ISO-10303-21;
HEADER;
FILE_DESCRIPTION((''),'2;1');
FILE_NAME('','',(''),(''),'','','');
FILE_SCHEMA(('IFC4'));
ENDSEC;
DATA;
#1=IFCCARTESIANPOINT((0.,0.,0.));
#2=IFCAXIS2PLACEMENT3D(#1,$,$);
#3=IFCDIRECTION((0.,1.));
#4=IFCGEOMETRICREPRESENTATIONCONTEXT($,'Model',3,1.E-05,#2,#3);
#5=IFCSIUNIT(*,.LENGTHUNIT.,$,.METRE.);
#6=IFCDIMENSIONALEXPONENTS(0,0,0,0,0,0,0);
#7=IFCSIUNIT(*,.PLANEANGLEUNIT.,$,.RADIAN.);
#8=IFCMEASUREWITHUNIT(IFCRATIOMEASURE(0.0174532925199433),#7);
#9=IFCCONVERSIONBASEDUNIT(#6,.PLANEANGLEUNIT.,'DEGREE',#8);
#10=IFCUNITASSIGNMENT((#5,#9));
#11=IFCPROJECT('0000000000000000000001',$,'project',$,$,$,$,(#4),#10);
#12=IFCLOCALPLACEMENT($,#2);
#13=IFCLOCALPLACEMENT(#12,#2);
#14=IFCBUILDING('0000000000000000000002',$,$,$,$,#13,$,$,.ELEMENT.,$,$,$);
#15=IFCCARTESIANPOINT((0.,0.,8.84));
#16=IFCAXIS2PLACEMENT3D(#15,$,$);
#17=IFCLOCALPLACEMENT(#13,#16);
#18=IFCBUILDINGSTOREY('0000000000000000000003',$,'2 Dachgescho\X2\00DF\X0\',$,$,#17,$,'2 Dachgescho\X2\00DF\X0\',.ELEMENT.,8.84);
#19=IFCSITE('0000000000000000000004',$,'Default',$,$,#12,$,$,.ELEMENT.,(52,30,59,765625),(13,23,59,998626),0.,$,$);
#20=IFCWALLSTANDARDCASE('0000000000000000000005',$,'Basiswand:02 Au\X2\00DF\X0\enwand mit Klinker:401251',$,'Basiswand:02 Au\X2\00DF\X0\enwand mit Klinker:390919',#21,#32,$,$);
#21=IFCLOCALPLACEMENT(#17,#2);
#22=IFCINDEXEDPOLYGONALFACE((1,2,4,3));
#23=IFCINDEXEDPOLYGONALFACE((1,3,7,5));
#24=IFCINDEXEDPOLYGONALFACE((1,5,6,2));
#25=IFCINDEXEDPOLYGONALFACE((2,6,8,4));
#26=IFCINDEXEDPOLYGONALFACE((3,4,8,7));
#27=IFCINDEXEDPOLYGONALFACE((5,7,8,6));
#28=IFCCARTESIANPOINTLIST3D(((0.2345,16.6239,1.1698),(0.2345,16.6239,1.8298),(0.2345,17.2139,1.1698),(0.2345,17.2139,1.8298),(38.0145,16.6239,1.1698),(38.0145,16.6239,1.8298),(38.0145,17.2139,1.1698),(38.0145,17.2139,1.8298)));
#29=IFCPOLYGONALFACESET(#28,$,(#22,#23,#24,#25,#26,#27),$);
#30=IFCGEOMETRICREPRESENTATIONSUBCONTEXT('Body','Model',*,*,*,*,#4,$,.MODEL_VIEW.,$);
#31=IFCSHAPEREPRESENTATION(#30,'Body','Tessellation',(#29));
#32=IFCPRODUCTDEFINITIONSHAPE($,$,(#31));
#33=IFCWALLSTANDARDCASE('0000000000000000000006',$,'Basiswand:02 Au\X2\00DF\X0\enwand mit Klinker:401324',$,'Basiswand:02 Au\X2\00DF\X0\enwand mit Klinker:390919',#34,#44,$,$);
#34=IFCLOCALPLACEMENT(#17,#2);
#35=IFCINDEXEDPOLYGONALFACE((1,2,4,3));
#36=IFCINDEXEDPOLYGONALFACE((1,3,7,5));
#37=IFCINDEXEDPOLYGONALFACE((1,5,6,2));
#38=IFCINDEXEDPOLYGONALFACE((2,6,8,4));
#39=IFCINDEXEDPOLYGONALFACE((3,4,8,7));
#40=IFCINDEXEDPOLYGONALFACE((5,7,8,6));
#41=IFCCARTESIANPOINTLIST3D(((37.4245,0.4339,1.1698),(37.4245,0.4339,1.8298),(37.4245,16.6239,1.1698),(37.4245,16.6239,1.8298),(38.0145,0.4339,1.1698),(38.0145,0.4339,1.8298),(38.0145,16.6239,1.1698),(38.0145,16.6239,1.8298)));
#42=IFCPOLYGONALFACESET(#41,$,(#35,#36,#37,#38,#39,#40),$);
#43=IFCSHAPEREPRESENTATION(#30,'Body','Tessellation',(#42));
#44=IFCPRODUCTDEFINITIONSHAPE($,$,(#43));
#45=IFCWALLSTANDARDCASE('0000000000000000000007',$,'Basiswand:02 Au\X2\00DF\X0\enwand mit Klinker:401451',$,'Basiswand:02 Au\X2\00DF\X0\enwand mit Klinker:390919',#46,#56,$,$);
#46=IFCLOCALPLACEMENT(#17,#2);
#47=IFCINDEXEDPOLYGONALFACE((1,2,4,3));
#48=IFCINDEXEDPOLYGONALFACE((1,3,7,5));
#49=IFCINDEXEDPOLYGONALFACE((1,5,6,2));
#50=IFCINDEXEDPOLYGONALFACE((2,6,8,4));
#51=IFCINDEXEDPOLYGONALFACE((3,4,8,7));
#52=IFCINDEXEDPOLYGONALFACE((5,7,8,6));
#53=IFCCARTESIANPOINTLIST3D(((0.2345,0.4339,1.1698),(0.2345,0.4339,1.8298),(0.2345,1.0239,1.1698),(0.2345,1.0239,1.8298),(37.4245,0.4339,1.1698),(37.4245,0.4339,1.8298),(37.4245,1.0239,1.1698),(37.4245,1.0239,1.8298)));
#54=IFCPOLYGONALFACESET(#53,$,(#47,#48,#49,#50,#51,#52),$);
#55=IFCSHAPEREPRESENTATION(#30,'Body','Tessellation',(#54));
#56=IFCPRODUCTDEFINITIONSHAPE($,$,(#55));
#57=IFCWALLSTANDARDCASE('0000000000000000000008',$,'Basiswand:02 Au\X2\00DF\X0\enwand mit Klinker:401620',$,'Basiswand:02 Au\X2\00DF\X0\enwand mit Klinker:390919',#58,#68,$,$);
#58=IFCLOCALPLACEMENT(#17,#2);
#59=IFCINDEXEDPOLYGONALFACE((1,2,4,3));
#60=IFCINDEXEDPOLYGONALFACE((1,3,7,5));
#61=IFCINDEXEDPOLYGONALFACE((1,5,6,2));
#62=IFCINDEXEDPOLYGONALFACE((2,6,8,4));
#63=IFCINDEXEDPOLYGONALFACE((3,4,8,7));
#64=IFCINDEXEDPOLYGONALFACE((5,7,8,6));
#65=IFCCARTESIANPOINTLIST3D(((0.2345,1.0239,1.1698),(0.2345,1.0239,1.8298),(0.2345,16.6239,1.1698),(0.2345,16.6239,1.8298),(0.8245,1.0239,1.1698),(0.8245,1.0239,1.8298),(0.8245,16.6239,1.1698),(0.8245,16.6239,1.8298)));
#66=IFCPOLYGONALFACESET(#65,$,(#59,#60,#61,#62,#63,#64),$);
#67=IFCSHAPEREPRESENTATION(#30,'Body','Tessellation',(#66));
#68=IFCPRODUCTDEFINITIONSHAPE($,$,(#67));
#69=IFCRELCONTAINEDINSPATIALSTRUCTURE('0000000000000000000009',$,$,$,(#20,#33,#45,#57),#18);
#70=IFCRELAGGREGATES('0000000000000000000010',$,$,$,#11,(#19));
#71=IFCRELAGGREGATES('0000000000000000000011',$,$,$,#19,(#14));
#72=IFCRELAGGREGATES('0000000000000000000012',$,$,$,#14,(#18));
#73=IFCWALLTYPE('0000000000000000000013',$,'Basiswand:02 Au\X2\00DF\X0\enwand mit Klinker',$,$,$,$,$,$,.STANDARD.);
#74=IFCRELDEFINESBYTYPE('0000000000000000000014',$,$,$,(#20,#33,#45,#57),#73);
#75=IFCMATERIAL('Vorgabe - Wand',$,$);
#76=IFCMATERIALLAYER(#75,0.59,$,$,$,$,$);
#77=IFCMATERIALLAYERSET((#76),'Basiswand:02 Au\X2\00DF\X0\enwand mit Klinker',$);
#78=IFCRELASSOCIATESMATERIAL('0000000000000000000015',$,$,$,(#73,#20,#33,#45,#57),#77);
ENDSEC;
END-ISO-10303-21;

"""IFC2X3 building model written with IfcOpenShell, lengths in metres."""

from ifc_helpers import new_model, entity, si_unit, converted_unit, direction, frame, frame_2d, origin, place, context, subcontext, project, spatial, rectangle, extrude, material, layer, layer_set, layer_usage, type_object, element, save


model = new_model("IFC2X3")

# Units and contexts
model_context = context("Model", 3, precision=1e-05, world=origin(), true_north=direction((0.0, 1.0)))
body_context = subcontext(model_context, "Body", "Model", "MODEL_VIEW")
ifc_project = project(units=[si_unit("LENGTHUNIT", "METRE"), converted_unit("PLANEANGLEUNIT", "DEGREE", entity("IfcRatioMeasure", 0.0174532925199433), si_unit("PLANEANGLEUNIT", "RADIAN"), dimensions=[0, 0, 0, 0, 0, 0, 0])], contexts=[model_context])

# Site, building, storey
site_placement = place(None, origin())
site = spatial("IfcSite", under=ifc_project, at=site_placement, Name="Default", CompositionType="ELEMENT", RefLatitude=(52, 30, 59, 765625), RefLongitude=(13, 23, 59, 998626), RefElevation=0.0)
building_placement = place(site_placement, origin())
building = spatial("IfcBuilding", under=site, at=building_placement, CompositionType="ELEMENT")
storey_placement = place(building_placement, frame((0.0, 0.0, 8.84)))
storey = spatial("IfcBuildingStorey", under=building, at=storey_placement, Name="2 Dachgeschoß", LongName="2 Dachgeschoß", CompositionType="ELEMENT", Elevation=8.84)

# Walls
ifc_material_1 = material(Name="Vorgabe - Wand")
ifc_layer_1 = layer(ifc_material_1, 0.59)
ifc_layer_set_1 = layer_set([ifc_layer_1], Name="Basiswand:02 Außenwand mit Klinker")
ifc_layer_usage_1 = layer_usage(ifc_layer_set_1, "AXIS2", "NEGATIVE", 0.295)
wall_type = type_object("IfcWallType", Name="Basiswand:02 Außenwand mit Klinker", PredefinedType="STANDARD", material=ifc_layer_set_1)
wall_1_placement = place(storey_placement, frame((0.2345, 16.9189, 1.1698), z_axis=(0.0, 0.0, 1.0), x_axis=(1.0, 0.0, 0.0)))
element("IfcWallStandardCase", 1, at=wall_1_placement, inside=storey, type_object=wall_type, material=ifc_layer_usage_1, Name="Basiswand:02 Außenwand mit Klinker:401251", ObjectType="Basiswand:02 Außenwand mit Klinker:390919", context=body_context, shape_type="SweptSolid", body=[
    extrude(rectangle(XDim=37.78, YDim=0.59, at=frame_2d((18.89, 0.0), x_axis=(-1.0, 0.0))), origin(), (0.0, 0.0, 1.0), 0.66),
])
ifc_layer_usage_2 = layer_usage(ifc_layer_set_1, "AXIS2", "NEGATIVE", 0.295)
wall_2_placement = place(storey_placement, frame((37.7195, 16.6239, 1.1698), z_axis=(0.0, 0.0, 1.0), x_axis=(0.0, -1.0, 0.0)))
element("IfcWallStandardCase", 2, at=wall_2_placement, inside=storey, type_object=wall_type, material=ifc_layer_usage_2, Name="Basiswand:02 Außenwand mit Klinker:401324", ObjectType="Basiswand:02 Außenwand mit Klinker:390919", context=body_context, shape_type="SweptSolid", body=[
    extrude(rectangle(XDim=16.19, YDim=0.59, at=frame_2d((8.095, 0.0), x_axis=(-1.0, 0.0))), origin(), (0.0, 0.0, 1.0), 0.66),
])
ifc_layer_usage_3 = layer_usage(ifc_layer_set_1, "AXIS2", "NEGATIVE", 0.295)
wall_3_placement = place(storey_placement, frame((37.4245, 0.7289, 1.1698), z_axis=(0.0, 0.0, 1.0), x_axis=(-1.0, 0.0, 0.0)))
element("IfcWallStandardCase", 3, at=wall_3_placement, inside=storey, type_object=wall_type, material=ifc_layer_usage_3, Name="Basiswand:02 Außenwand mit Klinker:401451", ObjectType="Basiswand:02 Außenwand mit Klinker:390919", context=body_context, shape_type="SweptSolid", body=[
    extrude(rectangle(XDim=37.19, YDim=0.59, at=frame_2d((18.595, 0.0), x_axis=(-1.0, 0.0))), origin(), (0.0, 0.0, 1.0), 0.66),
])
ifc_layer_usage_4 = layer_usage(ifc_layer_set_1, "AXIS2", "NEGATIVE", 0.295)
wall_4_placement = place(storey_placement, frame((0.5295, 1.0239, 1.1698), z_axis=(0.0, 0.0, 1.0), x_axis=(0.0, 1.0, 0.0)))
element("IfcWallStandardCase", 4, at=wall_4_placement, inside=storey, type_object=wall_type, material=ifc_layer_usage_4, Name="Basiswand:02 Außenwand mit Klinker:401620", ObjectType="Basiswand:02 Außenwand mit Klinker:390919", context=body_context, shape_type="SweptSolid", body=[
    extrude(rectangle(XDim=15.6, YDim=0.59, at=frame_2d((7.8, 0.0), x_axis=(-1.0, 0.0))), origin(), (0.0, 0.0, 1.0), 0.66),
])

save(model, "model.ifc")
